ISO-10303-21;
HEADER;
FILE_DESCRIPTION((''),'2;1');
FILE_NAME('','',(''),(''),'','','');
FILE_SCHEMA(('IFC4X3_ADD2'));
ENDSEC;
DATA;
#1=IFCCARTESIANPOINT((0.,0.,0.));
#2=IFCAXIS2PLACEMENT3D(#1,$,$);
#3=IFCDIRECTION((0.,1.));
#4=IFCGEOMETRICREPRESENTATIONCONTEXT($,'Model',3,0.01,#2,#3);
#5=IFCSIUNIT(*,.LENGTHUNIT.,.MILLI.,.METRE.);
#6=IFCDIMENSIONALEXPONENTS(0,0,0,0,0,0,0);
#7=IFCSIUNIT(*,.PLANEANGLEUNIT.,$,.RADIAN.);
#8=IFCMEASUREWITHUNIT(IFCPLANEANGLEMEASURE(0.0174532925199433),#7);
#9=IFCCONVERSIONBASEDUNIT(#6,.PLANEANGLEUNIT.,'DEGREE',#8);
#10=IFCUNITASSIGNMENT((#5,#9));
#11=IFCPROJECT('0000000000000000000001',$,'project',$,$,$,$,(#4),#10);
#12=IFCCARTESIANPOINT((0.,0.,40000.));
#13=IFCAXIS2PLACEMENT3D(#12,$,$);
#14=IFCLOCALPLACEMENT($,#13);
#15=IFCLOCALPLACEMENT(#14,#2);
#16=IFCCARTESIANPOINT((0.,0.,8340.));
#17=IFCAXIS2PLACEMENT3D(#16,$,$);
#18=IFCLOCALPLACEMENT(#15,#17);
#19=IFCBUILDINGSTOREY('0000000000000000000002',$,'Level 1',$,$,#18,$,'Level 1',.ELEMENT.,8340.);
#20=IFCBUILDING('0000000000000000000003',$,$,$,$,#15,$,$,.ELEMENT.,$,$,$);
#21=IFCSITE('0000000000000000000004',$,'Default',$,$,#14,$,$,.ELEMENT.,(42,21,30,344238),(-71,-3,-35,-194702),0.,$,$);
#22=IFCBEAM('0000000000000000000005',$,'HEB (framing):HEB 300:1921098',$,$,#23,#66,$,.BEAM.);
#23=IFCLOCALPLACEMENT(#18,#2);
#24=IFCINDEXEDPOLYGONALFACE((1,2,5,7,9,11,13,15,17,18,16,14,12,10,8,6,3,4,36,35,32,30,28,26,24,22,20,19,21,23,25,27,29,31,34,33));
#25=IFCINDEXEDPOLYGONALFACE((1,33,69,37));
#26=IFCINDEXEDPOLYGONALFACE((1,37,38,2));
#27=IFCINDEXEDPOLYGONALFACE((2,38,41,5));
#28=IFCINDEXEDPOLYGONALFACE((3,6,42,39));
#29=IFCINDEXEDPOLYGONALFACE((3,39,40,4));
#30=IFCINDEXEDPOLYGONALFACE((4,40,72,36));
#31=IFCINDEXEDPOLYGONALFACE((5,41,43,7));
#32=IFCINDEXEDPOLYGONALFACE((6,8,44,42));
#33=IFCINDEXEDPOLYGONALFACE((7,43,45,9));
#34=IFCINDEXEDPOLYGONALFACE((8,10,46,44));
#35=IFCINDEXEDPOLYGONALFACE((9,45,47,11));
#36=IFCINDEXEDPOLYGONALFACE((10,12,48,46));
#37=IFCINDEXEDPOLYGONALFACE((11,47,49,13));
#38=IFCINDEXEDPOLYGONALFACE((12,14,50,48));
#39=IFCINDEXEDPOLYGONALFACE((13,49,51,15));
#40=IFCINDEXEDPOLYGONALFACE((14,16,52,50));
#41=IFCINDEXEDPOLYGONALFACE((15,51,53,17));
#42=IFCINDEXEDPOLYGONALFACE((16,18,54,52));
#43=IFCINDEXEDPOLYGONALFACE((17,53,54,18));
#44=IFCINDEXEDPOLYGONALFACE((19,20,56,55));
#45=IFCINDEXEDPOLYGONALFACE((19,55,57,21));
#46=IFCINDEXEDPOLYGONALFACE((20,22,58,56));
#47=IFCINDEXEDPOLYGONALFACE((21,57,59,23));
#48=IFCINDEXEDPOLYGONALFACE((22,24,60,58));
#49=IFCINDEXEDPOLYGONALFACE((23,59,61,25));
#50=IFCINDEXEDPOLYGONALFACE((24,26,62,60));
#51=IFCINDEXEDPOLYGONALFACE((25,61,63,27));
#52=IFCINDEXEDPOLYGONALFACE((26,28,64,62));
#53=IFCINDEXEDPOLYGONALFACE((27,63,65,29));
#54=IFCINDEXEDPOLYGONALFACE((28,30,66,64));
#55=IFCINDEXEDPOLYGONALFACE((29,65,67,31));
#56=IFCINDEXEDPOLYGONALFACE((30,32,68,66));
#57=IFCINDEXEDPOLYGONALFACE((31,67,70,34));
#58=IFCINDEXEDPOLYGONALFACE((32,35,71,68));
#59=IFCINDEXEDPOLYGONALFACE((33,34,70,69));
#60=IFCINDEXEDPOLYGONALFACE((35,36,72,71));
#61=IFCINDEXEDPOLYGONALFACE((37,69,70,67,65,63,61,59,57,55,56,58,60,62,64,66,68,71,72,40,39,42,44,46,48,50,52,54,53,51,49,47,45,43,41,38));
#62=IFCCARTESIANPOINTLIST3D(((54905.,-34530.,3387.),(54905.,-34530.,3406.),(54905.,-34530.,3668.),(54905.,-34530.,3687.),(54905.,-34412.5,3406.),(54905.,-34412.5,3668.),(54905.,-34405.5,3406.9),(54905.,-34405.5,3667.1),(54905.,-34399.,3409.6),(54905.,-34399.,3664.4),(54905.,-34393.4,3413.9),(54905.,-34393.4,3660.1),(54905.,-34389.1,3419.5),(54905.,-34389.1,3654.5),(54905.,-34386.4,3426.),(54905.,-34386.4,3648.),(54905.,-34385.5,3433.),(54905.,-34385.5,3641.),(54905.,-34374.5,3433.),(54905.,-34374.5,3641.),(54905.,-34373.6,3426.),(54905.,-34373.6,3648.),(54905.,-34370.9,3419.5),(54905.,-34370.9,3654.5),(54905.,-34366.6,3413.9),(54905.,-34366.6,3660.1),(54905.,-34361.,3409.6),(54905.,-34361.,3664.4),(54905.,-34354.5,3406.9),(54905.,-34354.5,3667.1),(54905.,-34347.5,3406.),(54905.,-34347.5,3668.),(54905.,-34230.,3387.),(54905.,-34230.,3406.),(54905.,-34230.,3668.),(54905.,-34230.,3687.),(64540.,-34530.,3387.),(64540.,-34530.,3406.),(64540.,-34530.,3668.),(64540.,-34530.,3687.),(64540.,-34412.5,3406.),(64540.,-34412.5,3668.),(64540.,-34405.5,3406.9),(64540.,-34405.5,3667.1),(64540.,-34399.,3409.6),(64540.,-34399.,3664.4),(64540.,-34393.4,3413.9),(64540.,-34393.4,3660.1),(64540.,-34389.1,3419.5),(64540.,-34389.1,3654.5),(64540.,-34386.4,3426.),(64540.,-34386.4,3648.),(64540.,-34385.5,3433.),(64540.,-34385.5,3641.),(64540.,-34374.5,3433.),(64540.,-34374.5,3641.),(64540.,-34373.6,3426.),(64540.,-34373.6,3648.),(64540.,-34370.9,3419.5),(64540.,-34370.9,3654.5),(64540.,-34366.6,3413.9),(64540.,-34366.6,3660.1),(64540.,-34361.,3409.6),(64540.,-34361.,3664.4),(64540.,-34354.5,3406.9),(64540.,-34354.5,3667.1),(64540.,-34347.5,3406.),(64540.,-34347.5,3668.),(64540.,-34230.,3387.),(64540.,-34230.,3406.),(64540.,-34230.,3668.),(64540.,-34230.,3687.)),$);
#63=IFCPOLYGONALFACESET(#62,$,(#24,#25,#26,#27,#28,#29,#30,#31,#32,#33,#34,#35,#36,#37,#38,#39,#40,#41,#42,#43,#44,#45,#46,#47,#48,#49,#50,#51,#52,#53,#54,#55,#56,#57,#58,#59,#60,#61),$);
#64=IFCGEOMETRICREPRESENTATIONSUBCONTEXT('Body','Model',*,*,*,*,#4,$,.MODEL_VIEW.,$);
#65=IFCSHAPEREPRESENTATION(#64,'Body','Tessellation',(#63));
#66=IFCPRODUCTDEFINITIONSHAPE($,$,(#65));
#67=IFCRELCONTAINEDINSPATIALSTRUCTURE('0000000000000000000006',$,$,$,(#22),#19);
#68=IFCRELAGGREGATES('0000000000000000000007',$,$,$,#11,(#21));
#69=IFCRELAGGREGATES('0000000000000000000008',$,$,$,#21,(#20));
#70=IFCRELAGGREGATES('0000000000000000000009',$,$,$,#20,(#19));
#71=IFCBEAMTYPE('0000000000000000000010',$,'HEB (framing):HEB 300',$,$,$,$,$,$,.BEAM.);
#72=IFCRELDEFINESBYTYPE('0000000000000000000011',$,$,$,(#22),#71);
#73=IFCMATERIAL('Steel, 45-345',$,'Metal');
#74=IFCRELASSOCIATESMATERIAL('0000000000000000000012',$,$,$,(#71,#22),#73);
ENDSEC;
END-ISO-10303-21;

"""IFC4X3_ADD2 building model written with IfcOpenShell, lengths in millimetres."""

from ifc_helpers import new_model, entity, si_unit, converted_unit, direction, frame, frame_2d, origin, place, context, subcontext, project, spatial, polyline, circle_curve, parameter, trimmed, segment, composite_curve, outline, extrude, source, transform, mapped, material, material_profile, profile_set, profile_usage, type_object, type_shapes, element, save


model = new_model("IFC4X3_ADD2")

# Units and contexts
model_context = context("Model", 3, precision=0.01, world=origin(), true_north=direction((0.0, 1.0)))
body_context = subcontext(model_context, "Body", "Model", "MODEL_VIEW")
ifc_project = project(units=[si_unit("LENGTHUNIT", "METRE", prefix="MILLI"), converted_unit("PLANEANGLEUNIT", "DEGREE", entity("IfcPlaneAngleMeasure", 0.0174532925199433), si_unit("PLANEANGLEUNIT", "RADIAN"), dimensions=[0, 0, 0, 0, 0, 0, 0])], contexts=[model_context])

# Site, building, storey
site_placement = place(None, frame((0.0, 0.0, 40000.0)))
site = spatial("IfcSite", under=ifc_project, at=site_placement, Name="Default", CompositionType="ELEMENT", RefLatitude=(42, 21, 30, 344238), RefLongitude=(-71, -3, -35, -194702), RefElevation=0.0)
building_placement = place(site_placement, origin())
building = spatial("IfcBuilding", under=site, at=building_placement, CompositionType="ELEMENT")
storey_placement = place(building_placement, frame((0.0, 0.0, 8340.0)))
storey = spatial("IfcBuildingStorey", under=building, at=storey_placement, Name="Level 1", LongName="Level 1", CompositionType="ELEMENT", Elevation=8340.0)

# Shared definitions
ifc_material_1 = material(Name="Steel, 45-345", Category="Metal")

# Beam
ifc_material_profile_1 = material_profile(ifc_material_1, outline(composite_curve([segment(polyline([(-150.0, -131.0), (-150.0, -150.0)]), True, "CONTINUOUS"), segment(polyline([(-150.0, -150.0), (150.0, -150.0)]), True, "CONTINUOUS"), segment(polyline([(150.0, -150.0), (150.0, -131.0)]), True, "CONTINUOUS"), segment(polyline([(150.0, -131.0), (32.5, -131.0)]), True, "CONTINUOUS"), segment(trimmed(circle_curve(frame_2d((32.5, -104.0), x_axis=(1.0, 0.0)), 27.0), [parameter(180.0)], [parameter(270.0)], True, "PARAMETER"), False, "CONTINUOUS"), segment(polyline([(5.5, -104.0), (5.5, 104.0)]), True, "CONTINUOUS"), segment(trimmed(circle_curve(frame_2d((32.5, 104.0), x_axis=(1.0, 0.0)), 27.0), [parameter(90.0)], [parameter(180.0)], True, "PARAMETER"), False, "CONTINUOUS"), segment(polyline([(32.5, 131.0), (150.0, 131.0)]), True, "CONTINUOUS"), segment(polyline([(150.0, 131.0), (150.0, 150.0)]), True, "CONTINUOUS"), segment(polyline([(150.0, 150.0), (-150.0, 150.0)]), True, "CONTINUOUS"), segment(polyline([(-150.0, 150.0), (-150.0, 131.0)]), True, "CONTINUOUS"), segment(polyline([(-150.0, 131.0), (-32.5, 131.0)]), True, "CONTINUOUS"), segment(trimmed(circle_curve(frame_2d((-32.5, 104.0), x_axis=(1.0, 0.0)), 27.0), [parameter(360.0)], [parameter(90.0)], True, "PARAMETER"), False, "CONTINUOUS"), segment(polyline([(-5.5, 104.0), (-5.5, -104.0)]), True, "CONTINUOUS"), segment(trimmed(circle_curve(frame_2d((-32.5, -104.0), x_axis=(1.0, 0.0)), 27.0), [parameter(270.0)], [parameter(0.0)], True, "PARAMETER"), False, "CONTINUOUS"), segment(polyline([(-32.5, -131.0), (-150.0, -131.0)]), True, "CONTINUOUS")], self_intersect=False)), Name="HEB 300")
ifc_profile_set_1 = profile_set([ifc_material_profile_1], Name="HEB 300")
ifc_profile_usage_1 = profile_usage(ifc_profile_set_1, cardinal=8)
beam_type_1 = type_object("IfcBeamType", Name="HEB (framing):HEB 300", PredefinedType="BEAM", material=ifc_profile_set_1)
shared_shape_1 = source(origin(), body_context, "Body", "SweptSolid", [
    extrude(outline(composite_curve([segment(polyline([(-150.0, -131.0), (-150.0, -150.0)]), True, "CONTINUOUS"), segment(polyline([(-150.0, -150.0), (150.0, -150.0)]), True, "CONTINUOUS"), segment(polyline([(150.0, -150.0), (150.0, -131.0)]), True, "CONTINUOUS"), segment(polyline([(150.0, -131.0), (32.5, -131.0)]), True, "CONTINUOUS"), segment(trimmed(circle_curve(frame_2d((32.5, -104.0), x_axis=(1.0, 0.0)), 27.0), [parameter(180.0)], [parameter(270.0)], True, "PARAMETER"), False, "CONTINUOUS"), segment(polyline([(5.5, -104.0), (5.5, 104.0)]), True, "CONTINUOUS"), segment(trimmed(circle_curve(frame_2d((32.5, 104.0), x_axis=(1.0, 0.0)), 27.0), [parameter(90.0)], [parameter(180.0)], True, "PARAMETER"), False, "CONTINUOUS"), segment(polyline([(32.5, 131.0), (150.0, 131.0)]), True, "CONTINUOUS"), segment(polyline([(150.0, 131.0), (150.0, 150.0)]), True, "CONTINUOUS"), segment(polyline([(150.0, 150.0), (-150.0, 150.0)]), True, "CONTINUOUS"), segment(polyline([(-150.0, 150.0), (-150.0, 131.0)]), True, "CONTINUOUS"), segment(polyline([(-150.0, 131.0), (-32.5, 131.0)]), True, "CONTINUOUS"), segment(trimmed(circle_curve(frame_2d((-32.5, 104.0), x_axis=(1.0, 0.0)), 27.0), [parameter(360.0)], [parameter(90.0)], True, "PARAMETER"), False, "CONTINUOUS"), segment(polyline([(-5.5, 104.0), (-5.5, -104.0)]), True, "CONTINUOUS"), segment(trimmed(circle_curve(frame_2d((-32.5, -104.0), x_axis=(1.0, 0.0)), 27.0), [parameter(270.0)], [parameter(0.0)], True, "PARAMETER"), False, "CONTINUOUS"), segment(polyline([(-32.5, -131.0), (-150.0, -131.0)]), True, "CONTINUOUS")], self_intersect=False)), frame((-4700.0, 0.0, 0.0), z_axis=(-1.0, 0.0, 0.0), x_axis=(0.0, -1.0, 0.0)), (0.0, 0.0, -1.0), 9635.0),
])
type_shapes(beam_type_1, [shared_shape_1])
beam_1_placement = place(storey_placement, frame((59605.0, -34380.0, 3537.0)))
element("IfcBeam", 1, at=beam_1_placement, inside=storey, type_object=beam_type_1, material=ifc_profile_usage_1, Name="HEB (framing):HEB 300:1921098", PredefinedType="BEAM", context=body_context, shape_type="MappedRepresentation", body=[
    mapped(shared_shape_1, transform((0.0, 0.0, 0.0), scale=1.0)),
])

save(model, "model.ifc")
